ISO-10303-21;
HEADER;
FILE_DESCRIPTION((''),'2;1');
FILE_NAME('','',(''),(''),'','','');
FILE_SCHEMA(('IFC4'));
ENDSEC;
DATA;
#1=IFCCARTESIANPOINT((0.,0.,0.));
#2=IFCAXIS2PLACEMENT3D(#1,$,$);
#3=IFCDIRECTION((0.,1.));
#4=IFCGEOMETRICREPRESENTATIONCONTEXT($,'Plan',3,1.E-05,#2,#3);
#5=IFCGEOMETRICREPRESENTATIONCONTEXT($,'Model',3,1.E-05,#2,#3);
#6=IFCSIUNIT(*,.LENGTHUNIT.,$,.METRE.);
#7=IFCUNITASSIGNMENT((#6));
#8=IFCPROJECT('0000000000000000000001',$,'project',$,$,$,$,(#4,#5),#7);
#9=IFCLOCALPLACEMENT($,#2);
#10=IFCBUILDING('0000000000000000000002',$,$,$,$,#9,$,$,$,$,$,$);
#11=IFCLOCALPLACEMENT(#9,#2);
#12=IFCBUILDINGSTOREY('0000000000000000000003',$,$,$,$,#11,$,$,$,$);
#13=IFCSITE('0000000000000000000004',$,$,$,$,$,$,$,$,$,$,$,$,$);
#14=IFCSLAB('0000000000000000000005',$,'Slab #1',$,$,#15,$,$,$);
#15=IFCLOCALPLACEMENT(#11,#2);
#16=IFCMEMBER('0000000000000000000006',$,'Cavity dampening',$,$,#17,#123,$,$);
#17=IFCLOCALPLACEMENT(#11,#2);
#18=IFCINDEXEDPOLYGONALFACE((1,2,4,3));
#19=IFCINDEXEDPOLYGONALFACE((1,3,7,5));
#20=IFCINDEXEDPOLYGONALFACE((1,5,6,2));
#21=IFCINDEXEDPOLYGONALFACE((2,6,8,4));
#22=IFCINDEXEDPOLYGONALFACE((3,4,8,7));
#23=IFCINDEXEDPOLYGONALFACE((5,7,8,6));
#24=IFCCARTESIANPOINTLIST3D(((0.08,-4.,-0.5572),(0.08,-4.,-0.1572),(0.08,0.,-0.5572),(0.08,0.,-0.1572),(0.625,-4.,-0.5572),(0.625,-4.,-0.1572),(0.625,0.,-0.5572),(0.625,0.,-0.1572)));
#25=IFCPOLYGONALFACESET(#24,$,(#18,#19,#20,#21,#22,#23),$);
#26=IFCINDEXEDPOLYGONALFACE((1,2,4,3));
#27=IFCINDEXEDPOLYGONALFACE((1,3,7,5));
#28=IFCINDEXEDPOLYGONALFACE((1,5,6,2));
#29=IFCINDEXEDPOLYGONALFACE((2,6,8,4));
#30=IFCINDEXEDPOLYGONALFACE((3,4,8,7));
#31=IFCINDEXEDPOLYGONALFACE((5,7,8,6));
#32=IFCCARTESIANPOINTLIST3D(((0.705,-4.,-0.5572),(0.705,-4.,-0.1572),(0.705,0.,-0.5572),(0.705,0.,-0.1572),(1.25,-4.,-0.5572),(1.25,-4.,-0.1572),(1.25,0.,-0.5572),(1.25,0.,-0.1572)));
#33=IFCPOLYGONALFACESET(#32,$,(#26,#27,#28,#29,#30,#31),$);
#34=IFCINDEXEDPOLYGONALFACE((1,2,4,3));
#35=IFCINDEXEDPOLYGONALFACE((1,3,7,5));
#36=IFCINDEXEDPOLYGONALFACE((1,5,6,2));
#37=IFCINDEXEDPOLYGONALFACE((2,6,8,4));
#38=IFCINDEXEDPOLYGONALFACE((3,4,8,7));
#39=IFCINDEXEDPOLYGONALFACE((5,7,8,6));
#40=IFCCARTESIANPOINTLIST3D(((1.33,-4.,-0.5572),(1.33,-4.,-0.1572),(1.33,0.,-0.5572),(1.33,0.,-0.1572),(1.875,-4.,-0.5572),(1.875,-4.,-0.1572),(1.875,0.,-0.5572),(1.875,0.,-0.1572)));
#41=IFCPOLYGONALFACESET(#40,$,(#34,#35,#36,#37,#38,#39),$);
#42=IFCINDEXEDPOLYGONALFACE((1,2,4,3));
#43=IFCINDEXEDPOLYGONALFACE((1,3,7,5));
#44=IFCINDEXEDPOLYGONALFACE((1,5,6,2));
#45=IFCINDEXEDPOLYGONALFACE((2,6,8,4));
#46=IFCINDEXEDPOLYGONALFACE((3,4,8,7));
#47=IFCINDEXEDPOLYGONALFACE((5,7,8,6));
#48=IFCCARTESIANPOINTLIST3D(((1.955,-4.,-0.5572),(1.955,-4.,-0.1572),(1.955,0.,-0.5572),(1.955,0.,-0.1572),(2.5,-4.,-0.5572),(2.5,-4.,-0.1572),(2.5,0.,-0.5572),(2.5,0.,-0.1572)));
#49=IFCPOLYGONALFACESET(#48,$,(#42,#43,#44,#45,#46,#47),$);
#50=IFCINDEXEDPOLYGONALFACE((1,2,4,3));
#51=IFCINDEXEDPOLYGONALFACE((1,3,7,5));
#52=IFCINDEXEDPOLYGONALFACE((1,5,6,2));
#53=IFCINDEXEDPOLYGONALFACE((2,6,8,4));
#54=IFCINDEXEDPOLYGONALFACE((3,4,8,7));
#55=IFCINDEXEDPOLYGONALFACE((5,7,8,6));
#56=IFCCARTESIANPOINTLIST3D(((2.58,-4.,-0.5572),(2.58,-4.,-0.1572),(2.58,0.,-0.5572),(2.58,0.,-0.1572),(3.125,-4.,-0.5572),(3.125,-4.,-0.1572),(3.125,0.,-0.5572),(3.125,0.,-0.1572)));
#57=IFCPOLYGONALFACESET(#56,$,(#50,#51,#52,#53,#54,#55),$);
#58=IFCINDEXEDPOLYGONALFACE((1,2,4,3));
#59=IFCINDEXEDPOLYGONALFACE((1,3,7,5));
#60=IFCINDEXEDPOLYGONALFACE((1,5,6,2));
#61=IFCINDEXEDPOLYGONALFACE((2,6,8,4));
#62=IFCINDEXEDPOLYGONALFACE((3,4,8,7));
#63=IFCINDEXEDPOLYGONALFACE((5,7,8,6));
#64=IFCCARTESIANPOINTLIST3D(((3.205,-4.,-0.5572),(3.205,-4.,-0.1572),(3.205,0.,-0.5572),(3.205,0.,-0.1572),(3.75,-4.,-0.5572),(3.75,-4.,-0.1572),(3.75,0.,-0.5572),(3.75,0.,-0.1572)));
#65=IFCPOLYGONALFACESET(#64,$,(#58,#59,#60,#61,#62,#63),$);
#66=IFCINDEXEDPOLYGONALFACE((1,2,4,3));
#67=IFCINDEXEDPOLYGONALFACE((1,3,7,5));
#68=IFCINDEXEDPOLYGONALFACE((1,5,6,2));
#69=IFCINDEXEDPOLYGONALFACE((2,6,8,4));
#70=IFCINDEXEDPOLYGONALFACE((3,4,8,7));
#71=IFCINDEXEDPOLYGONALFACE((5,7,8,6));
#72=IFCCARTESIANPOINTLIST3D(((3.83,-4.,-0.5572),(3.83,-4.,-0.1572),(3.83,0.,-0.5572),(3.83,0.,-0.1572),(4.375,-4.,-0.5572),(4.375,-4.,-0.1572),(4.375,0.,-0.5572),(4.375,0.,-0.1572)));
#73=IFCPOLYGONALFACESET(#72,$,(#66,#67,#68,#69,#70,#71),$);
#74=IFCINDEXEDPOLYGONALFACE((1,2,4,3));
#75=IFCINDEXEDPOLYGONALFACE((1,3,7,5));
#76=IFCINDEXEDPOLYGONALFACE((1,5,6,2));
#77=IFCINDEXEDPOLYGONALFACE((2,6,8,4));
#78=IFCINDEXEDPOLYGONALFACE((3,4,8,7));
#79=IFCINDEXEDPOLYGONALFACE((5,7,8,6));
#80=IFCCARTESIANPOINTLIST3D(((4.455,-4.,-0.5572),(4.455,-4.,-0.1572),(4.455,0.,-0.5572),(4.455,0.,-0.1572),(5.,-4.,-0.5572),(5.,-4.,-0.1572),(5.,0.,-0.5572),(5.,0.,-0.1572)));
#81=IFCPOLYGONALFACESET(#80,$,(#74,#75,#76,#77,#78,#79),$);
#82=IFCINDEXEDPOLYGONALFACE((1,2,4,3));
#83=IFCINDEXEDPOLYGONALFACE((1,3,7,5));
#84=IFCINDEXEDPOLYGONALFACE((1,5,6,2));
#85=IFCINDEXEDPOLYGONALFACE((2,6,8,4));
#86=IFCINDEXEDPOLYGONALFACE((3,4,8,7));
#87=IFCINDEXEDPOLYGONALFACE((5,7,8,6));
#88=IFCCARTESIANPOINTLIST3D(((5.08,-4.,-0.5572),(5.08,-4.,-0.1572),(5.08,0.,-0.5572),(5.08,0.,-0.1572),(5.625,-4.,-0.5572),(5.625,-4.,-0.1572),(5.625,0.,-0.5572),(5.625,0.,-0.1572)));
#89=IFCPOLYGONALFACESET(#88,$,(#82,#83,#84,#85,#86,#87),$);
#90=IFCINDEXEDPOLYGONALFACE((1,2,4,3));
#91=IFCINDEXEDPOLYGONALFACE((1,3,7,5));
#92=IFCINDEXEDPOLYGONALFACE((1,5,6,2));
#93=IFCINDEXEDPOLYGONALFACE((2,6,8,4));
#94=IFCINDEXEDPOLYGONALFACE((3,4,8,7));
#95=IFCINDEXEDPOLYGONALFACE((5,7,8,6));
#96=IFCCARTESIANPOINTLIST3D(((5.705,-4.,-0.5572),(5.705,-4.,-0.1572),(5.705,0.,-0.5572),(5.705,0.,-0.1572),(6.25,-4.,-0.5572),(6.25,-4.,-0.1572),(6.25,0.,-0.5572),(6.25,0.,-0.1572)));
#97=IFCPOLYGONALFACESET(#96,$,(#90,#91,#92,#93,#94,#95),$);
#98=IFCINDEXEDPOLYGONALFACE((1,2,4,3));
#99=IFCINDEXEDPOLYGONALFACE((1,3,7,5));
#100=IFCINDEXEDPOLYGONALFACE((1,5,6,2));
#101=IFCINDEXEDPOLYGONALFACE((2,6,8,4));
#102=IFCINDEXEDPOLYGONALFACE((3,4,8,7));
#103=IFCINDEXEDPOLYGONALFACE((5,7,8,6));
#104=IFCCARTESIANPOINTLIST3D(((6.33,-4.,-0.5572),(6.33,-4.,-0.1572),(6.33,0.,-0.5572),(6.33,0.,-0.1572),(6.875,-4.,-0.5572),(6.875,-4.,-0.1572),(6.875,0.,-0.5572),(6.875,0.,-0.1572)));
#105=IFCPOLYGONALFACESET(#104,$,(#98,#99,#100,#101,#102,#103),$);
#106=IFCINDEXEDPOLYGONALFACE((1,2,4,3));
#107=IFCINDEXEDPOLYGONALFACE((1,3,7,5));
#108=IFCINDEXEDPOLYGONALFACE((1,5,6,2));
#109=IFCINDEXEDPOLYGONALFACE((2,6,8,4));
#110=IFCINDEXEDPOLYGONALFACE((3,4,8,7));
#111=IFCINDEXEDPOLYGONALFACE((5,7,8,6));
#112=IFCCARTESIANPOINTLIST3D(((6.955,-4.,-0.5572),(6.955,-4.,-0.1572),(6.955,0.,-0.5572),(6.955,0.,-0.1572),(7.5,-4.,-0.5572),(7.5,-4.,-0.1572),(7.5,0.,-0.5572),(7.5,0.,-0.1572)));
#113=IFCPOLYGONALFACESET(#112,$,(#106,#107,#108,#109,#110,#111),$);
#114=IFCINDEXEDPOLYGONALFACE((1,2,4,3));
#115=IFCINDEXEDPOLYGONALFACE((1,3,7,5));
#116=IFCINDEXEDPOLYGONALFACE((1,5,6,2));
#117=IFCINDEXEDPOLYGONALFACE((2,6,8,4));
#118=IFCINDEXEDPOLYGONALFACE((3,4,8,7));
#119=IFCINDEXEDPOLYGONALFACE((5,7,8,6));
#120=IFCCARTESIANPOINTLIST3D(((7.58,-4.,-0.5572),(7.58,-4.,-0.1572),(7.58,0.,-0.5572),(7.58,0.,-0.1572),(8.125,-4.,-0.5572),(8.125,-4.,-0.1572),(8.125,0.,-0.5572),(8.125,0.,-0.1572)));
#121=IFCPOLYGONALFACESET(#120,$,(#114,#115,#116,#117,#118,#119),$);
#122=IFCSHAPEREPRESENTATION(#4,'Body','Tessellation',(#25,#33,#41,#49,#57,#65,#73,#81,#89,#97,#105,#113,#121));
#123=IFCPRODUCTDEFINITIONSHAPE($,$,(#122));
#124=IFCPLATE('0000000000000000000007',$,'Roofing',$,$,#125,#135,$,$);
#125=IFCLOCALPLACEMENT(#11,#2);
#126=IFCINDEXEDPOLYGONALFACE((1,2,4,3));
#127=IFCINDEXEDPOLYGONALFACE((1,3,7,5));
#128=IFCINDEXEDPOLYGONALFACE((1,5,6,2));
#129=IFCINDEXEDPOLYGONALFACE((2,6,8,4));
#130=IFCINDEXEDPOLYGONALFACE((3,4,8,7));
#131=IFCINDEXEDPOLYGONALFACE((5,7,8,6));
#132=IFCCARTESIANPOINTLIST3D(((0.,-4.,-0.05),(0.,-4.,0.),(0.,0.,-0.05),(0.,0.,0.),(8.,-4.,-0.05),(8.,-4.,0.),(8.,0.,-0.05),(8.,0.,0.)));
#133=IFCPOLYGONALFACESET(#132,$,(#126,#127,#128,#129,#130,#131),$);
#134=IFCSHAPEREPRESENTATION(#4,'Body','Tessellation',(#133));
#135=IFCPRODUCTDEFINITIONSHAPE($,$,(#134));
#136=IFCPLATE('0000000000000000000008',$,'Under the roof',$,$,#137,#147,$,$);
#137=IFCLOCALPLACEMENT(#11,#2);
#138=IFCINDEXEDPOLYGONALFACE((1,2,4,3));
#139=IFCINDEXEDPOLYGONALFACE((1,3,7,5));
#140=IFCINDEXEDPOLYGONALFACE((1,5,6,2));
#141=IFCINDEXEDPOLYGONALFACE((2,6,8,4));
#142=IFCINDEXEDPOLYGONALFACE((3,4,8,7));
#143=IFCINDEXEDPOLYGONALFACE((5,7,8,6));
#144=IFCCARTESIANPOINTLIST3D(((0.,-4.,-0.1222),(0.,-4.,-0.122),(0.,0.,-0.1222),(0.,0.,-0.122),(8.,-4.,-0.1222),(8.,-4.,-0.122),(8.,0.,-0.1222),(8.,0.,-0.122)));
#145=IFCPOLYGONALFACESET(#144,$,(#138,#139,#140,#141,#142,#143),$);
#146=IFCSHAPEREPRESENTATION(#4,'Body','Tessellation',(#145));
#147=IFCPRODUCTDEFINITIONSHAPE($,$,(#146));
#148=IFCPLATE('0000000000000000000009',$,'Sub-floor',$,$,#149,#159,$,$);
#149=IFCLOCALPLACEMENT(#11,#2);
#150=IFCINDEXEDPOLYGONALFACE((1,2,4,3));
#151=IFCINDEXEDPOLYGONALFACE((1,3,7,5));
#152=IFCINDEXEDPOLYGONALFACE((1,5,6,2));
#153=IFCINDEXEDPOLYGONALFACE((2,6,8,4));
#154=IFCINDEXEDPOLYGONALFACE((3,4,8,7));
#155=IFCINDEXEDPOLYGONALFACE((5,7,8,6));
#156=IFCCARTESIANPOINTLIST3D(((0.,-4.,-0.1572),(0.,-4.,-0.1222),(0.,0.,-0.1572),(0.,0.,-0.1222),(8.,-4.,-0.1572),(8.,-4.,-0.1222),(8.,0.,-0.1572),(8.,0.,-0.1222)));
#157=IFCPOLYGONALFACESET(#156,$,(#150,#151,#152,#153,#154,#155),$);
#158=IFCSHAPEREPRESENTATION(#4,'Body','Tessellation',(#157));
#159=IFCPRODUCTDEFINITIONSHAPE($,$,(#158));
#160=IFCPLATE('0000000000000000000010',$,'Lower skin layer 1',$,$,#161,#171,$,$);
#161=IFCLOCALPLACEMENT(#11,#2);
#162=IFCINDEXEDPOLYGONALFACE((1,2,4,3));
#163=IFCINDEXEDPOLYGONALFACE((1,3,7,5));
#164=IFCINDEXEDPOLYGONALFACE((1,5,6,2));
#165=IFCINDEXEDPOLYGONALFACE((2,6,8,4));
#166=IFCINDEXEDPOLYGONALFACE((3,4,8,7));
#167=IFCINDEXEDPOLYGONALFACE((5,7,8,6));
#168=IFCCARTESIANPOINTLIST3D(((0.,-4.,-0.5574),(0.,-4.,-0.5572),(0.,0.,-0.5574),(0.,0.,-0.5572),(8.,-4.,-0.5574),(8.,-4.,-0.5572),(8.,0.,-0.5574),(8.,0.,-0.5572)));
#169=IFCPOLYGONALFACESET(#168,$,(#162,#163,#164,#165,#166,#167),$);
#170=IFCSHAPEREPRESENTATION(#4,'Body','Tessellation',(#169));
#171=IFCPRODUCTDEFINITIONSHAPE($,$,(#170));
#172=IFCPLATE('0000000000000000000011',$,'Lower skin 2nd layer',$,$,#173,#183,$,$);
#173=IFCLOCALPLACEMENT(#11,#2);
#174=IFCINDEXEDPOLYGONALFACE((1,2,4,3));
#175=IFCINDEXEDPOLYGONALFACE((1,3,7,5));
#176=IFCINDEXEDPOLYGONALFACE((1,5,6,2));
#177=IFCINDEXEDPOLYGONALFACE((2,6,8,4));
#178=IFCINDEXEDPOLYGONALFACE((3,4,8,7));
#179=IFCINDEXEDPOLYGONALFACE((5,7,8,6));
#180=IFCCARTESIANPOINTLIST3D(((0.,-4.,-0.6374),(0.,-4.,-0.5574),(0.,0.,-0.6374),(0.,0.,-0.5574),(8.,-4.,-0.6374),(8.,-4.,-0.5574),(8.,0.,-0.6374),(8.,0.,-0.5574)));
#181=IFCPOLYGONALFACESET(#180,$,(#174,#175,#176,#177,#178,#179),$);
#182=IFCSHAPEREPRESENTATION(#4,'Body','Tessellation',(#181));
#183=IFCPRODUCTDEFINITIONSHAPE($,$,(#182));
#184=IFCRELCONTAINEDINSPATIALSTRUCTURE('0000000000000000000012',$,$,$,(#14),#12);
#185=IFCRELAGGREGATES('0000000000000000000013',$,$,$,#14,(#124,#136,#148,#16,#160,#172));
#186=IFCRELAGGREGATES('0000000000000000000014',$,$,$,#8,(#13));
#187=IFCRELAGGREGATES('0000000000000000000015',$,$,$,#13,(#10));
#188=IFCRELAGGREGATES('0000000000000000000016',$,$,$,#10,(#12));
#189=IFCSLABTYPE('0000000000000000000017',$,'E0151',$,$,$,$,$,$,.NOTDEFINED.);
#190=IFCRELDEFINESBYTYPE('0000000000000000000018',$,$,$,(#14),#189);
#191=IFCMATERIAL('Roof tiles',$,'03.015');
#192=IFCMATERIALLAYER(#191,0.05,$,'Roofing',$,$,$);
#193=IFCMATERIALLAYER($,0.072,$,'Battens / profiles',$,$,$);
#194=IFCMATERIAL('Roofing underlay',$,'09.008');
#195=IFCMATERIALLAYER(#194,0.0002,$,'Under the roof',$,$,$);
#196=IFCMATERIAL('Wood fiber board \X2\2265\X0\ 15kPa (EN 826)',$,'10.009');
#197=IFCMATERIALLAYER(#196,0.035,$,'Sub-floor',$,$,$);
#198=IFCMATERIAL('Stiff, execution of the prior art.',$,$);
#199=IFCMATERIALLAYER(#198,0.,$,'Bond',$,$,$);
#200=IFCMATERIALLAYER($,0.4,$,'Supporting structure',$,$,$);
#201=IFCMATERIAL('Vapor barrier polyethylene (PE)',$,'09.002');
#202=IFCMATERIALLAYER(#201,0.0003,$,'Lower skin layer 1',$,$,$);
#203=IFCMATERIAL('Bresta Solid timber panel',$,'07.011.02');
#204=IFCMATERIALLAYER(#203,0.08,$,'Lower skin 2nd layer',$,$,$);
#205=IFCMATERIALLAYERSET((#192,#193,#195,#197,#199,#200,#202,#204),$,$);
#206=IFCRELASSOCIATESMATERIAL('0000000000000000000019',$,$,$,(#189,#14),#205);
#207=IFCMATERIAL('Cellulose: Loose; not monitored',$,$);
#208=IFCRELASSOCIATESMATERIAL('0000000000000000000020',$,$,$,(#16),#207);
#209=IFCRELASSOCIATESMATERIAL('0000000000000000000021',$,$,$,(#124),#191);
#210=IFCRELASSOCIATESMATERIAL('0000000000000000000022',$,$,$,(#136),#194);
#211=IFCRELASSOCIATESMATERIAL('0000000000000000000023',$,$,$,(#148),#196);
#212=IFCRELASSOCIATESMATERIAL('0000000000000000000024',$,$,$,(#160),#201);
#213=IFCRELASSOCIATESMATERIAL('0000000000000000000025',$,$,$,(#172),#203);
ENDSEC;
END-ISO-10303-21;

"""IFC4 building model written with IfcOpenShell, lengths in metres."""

from ifc_helpers import new_model, si_unit, direction, frame, frame_2d, origin, origin_with_axes, place, context, project, spatial, rectangle, extrude, material, layer, layer_set, type_object, element, aggregate, save


model = new_model("IFC4")

# Units and contexts
plan_context = context("Plan", 3, precision=1e-05, world=origin(), true_north=direction((0.0, 1.0)))
model_context = context("Model", 3, precision=1e-05, world=origin(), true_north=direction((0.0, 1.0)))
ifc_project = project(units=[si_unit("LENGTHUNIT", "METRE")], contexts=[plan_context, model_context])

# Site, building, storey
site = spatial("IfcSite", under=ifc_project)
building_placement = place(None, origin())
building = spatial("IfcBuilding", under=site, at=building_placement)
storey_placement = place(building_placement, origin())
storey = spatial("IfcBuildingStorey", under=building, at=storey_placement)

# Slab, member, plates
ifc_material_1 = material(Name="Roof tiles", Category="03.015")
ifc_layer_1 = layer(ifc_material_1, 0.05, Name="Roofing")
ifc_layer_2 = layer(None, 0.072, Name="Battens / profiles")
ifc_material_2 = material(Name="Roofing underlay", Category="09.008")
ifc_layer_3 = layer(ifc_material_2, 0.0002, Name="Under the roof")
ifc_material_3 = material(Name="Wood fiber board ≥ 15kPa (EN 826)", Category="10.009")
ifc_layer_4 = layer(ifc_material_3, 0.035, Name="Sub-floor")
ifc_material_4 = material(Name="Stiff, execution of the prior art.")
ifc_layer_5 = layer(ifc_material_4, 0.0, Name="Bond")
ifc_layer_6 = layer(None, 0.4, Name="Supporting structure")
ifc_material_5 = material(Name="Vapor barrier polyethylene (PE)", Category="09.002")
ifc_layer_7 = layer(ifc_material_5, 0.0003, Name="Lower skin layer 1")
ifc_material_6 = material(Name="Bresta Solid timber panel", Category="07.011.02")
ifc_layer_8 = layer(ifc_material_6, 0.08, Name="Lower skin 2nd layer")
ifc_layer_set = layer_set([ifc_layer_1, ifc_layer_2, ifc_layer_3, ifc_layer_4, ifc_layer_5, ifc_layer_6, ifc_layer_7, ifc_layer_8])
slab_type = type_object("IfcSlabType", Name="E0151", PredefinedType="NOTDEFINED", material=ifc_layer_set)
slab_placement = place(None, frame((0.0, 0.0, 0.0), z_axis=(0.0, 0.0, -1.0), x_axis=(1.0, 0.0, 0.0)))
slab = element("IfcSlab", 1, at=slab_placement, inside=storey, type_object=slab_type, material=ifc_layer_set, Name="Slab #1")
ifc_material_7 = material(Name="Cellulose: Loose; not monitored")
member_1_placement = place(slab_placement, origin())
member_1 = element("IfcMember", 2, at=member_1_placement, material=ifc_material_7, Name="Cavity dampening", context=plan_context, shape_type="SweptSolid", body=[
    extrude(rectangle(XDim=0.545, YDim=0.4, at=frame_2d((0.2725, 0.2), x_axis=(1.0, 0.0))), frame((0.08, 4.0, 0.1572), z_axis=(0.0, -1.0, 0.0), x_axis=(1.0, 0.0, 0.0)), (0.0, 0.0, 1.0), 4.0),
    extrude(rectangle(XDim=0.545, YDim=0.4, at=frame_2d((0.2725, 0.2), x_axis=(1.0, 0.0))), frame((0.705, 4.0, 0.1572), z_axis=(0.0, -1.0, 0.0), x_axis=(1.0, 0.0, 0.0)), (0.0, 0.0, 1.0), 4.0),
    extrude(rectangle(XDim=0.545, YDim=0.4, at=frame_2d((0.2725, 0.2), x_axis=(1.0, 0.0))), frame((1.33, 4.0, 0.1572), z_axis=(0.0, -1.0, 0.0), x_axis=(1.0, 0.0, 0.0)), (0.0, 0.0, 1.0), 4.0),
    extrude(rectangle(XDim=0.545, YDim=0.4, at=frame_2d((0.2725, 0.2), x_axis=(1.0, 0.0))), frame((1.955, 4.0, 0.1572), z_axis=(0.0, -1.0, 0.0), x_axis=(1.0, 0.0, 0.0)), (0.0, 0.0, 1.0), 4.0),
    extrude(rectangle(XDim=0.545, YDim=0.4, at=frame_2d((0.2725, 0.2), x_axis=(1.0, 0.0))), frame((2.58, 4.0, 0.1572), z_axis=(0.0, -1.0, 0.0), x_axis=(1.0, 0.0, 0.0)), (0.0, 0.0, 1.0), 4.0),
    extrude(rectangle(XDim=0.545, YDim=0.4, at=frame_2d((0.2725, 0.2), x_axis=(1.0, 0.0))), frame((3.205, 4.0, 0.1572), z_axis=(0.0, -1.0, 0.0), x_axis=(1.0, 0.0, 0.0)), (0.0, 0.0, 1.0), 4.0),
    extrude(rectangle(XDim=0.545, YDim=0.4, at=frame_2d((0.2725, 0.2), x_axis=(1.0, 0.0))), frame((3.83, 4.0, 0.1572), z_axis=(0.0, -1.0, 0.0), x_axis=(1.0, 0.0, 0.0)), (0.0, 0.0, 1.0), 4.0),
    extrude(rectangle(XDim=0.545, YDim=0.4, at=frame_2d((0.2725, 0.2), x_axis=(1.0, 0.0))), frame((4.455, 4.0, 0.1572), z_axis=(0.0, -1.0, 0.0), x_axis=(1.0, 0.0, 0.0)), (0.0, 0.0, 1.0), 4.0),
    extrude(rectangle(XDim=0.545, YDim=0.4, at=frame_2d((0.2725, 0.2), x_axis=(1.0, 0.0))), frame((5.08, 4.0, 0.1572), z_axis=(0.0, -1.0, 0.0), x_axis=(1.0, 0.0, 0.0)), (0.0, 0.0, 1.0), 4.0),
    extrude(rectangle(XDim=0.545, YDim=0.4, at=frame_2d((0.2725, 0.2), x_axis=(1.0, 0.0))), frame((5.705, 4.0, 0.1572), z_axis=(0.0, -1.0, 0.0), x_axis=(1.0, 0.0, 0.0)), (0.0, 0.0, 1.0), 4.0),
    extrude(rectangle(XDim=0.545, YDim=0.4, at=frame_2d((0.2725, 0.2), x_axis=(1.0, 0.0))), frame((6.33, 4.0, 0.1572), z_axis=(0.0, -1.0, 0.0), x_axis=(1.0, 0.0, 0.0)), (0.0, 0.0, 1.0), 4.0),
    extrude(rectangle(XDim=0.545, YDim=0.4, at=frame_2d((0.2725, 0.2), x_axis=(1.0, 0.0))), frame((6.955, 4.0, 0.1572), z_axis=(0.0, -1.0, 0.0), x_axis=(1.0, 0.0, 0.0)), (0.0, 0.0, 1.0), 4.0),
    extrude(rectangle(XDim=0.545, YDim=0.4, at=frame_2d((0.2725, 0.2), x_axis=(1.0, 0.0))), frame((7.58, 4.0, 0.1572), z_axis=(0.0, -1.0, 0.0), x_axis=(1.0, 0.0, 0.0)), (0.0, 0.0, 1.0), 4.0),
])
plate_1_placement = place(slab_placement, origin())
plate_1 = element("IfcPlate", 3, at=plate_1_placement, material=ifc_material_1, Name="Roofing", context=plan_context, shape_type="SweptSolid", body=[
    extrude(rectangle(XDim=8.0, YDim=4.0, at=frame_2d((4.0, 2.0), x_axis=(1.0, 0.0))), origin_with_axes(), (0.0, 0.0, 1.0), 0.05),
])
plate_2_placement = place(slab_placement, origin())
plate_2 = element("IfcPlate", 4, at=plate_2_placement, material=ifc_material_2, Name="Under the roof", context=plan_context, shape_type="SweptSolid", body=[
    extrude(rectangle(XDim=8.0, YDim=4.0, at=frame_2d((4.0, 2.0), x_axis=(1.0, 0.0))), frame((0.0, 0.0, 0.122), z_axis=(0.0, 0.0, 1.0), x_axis=(1.0, 0.0, 0.0)), (0.0, 0.0, 1.0), 0.0002),
])
plate_3_placement = place(slab_placement, origin())
plate_3 = element("IfcPlate", 5, at=plate_3_placement, material=ifc_material_3, Name="Sub-floor", context=plan_context, shape_type="SweptSolid", body=[
    extrude(rectangle(XDim=8.0, YDim=4.0, at=frame_2d((4.0, 2.0), x_axis=(1.0, 0.0))), frame((0.0, 0.0, 0.1222), z_axis=(0.0, 0.0, 1.0), x_axis=(1.0, 0.0, 0.0)), (0.0, 0.0, 1.0), 0.035),
])
plate_4_placement = place(slab_placement, origin())
plate_4 = element("IfcPlate", 6, at=plate_4_placement, material=ifc_material_5, Name="Lower skin layer 1", context=plan_context, shape_type="SweptSolid", body=[
    extrude(rectangle(XDim=8.0, YDim=4.0, at=frame_2d((4.0, 2.0), x_axis=(1.0, 0.0))), frame((0.0, 0.0, 0.5572), z_axis=(0.0, 0.0, 1.0), x_axis=(1.0, 0.0, 0.0)), (0.0, 0.0, 1.0), 0.0003),
])
plate_5_placement = place(slab_placement, origin())
plate_5 = element("IfcPlate", 7, at=plate_5_placement, material=ifc_material_6, Name="Lower skin 2nd layer", context=plan_context, shape_type="SweptSolid", body=[
    extrude(rectangle(XDim=8.0, YDim=4.0, at=frame_2d((4.0, 2.0), x_axis=(1.0, 0.0))), frame((0.0, 0.0, 0.5574), z_axis=(0.0, 0.0, 1.0), x_axis=(1.0, 0.0, 0.0)), (0.0, 0.0, 1.0), 0.08),
])
aggregate(slab, [plate_1, plate_2, plate_3, member_1, plate_4, plate_5])

save(model, "model.ifc")
